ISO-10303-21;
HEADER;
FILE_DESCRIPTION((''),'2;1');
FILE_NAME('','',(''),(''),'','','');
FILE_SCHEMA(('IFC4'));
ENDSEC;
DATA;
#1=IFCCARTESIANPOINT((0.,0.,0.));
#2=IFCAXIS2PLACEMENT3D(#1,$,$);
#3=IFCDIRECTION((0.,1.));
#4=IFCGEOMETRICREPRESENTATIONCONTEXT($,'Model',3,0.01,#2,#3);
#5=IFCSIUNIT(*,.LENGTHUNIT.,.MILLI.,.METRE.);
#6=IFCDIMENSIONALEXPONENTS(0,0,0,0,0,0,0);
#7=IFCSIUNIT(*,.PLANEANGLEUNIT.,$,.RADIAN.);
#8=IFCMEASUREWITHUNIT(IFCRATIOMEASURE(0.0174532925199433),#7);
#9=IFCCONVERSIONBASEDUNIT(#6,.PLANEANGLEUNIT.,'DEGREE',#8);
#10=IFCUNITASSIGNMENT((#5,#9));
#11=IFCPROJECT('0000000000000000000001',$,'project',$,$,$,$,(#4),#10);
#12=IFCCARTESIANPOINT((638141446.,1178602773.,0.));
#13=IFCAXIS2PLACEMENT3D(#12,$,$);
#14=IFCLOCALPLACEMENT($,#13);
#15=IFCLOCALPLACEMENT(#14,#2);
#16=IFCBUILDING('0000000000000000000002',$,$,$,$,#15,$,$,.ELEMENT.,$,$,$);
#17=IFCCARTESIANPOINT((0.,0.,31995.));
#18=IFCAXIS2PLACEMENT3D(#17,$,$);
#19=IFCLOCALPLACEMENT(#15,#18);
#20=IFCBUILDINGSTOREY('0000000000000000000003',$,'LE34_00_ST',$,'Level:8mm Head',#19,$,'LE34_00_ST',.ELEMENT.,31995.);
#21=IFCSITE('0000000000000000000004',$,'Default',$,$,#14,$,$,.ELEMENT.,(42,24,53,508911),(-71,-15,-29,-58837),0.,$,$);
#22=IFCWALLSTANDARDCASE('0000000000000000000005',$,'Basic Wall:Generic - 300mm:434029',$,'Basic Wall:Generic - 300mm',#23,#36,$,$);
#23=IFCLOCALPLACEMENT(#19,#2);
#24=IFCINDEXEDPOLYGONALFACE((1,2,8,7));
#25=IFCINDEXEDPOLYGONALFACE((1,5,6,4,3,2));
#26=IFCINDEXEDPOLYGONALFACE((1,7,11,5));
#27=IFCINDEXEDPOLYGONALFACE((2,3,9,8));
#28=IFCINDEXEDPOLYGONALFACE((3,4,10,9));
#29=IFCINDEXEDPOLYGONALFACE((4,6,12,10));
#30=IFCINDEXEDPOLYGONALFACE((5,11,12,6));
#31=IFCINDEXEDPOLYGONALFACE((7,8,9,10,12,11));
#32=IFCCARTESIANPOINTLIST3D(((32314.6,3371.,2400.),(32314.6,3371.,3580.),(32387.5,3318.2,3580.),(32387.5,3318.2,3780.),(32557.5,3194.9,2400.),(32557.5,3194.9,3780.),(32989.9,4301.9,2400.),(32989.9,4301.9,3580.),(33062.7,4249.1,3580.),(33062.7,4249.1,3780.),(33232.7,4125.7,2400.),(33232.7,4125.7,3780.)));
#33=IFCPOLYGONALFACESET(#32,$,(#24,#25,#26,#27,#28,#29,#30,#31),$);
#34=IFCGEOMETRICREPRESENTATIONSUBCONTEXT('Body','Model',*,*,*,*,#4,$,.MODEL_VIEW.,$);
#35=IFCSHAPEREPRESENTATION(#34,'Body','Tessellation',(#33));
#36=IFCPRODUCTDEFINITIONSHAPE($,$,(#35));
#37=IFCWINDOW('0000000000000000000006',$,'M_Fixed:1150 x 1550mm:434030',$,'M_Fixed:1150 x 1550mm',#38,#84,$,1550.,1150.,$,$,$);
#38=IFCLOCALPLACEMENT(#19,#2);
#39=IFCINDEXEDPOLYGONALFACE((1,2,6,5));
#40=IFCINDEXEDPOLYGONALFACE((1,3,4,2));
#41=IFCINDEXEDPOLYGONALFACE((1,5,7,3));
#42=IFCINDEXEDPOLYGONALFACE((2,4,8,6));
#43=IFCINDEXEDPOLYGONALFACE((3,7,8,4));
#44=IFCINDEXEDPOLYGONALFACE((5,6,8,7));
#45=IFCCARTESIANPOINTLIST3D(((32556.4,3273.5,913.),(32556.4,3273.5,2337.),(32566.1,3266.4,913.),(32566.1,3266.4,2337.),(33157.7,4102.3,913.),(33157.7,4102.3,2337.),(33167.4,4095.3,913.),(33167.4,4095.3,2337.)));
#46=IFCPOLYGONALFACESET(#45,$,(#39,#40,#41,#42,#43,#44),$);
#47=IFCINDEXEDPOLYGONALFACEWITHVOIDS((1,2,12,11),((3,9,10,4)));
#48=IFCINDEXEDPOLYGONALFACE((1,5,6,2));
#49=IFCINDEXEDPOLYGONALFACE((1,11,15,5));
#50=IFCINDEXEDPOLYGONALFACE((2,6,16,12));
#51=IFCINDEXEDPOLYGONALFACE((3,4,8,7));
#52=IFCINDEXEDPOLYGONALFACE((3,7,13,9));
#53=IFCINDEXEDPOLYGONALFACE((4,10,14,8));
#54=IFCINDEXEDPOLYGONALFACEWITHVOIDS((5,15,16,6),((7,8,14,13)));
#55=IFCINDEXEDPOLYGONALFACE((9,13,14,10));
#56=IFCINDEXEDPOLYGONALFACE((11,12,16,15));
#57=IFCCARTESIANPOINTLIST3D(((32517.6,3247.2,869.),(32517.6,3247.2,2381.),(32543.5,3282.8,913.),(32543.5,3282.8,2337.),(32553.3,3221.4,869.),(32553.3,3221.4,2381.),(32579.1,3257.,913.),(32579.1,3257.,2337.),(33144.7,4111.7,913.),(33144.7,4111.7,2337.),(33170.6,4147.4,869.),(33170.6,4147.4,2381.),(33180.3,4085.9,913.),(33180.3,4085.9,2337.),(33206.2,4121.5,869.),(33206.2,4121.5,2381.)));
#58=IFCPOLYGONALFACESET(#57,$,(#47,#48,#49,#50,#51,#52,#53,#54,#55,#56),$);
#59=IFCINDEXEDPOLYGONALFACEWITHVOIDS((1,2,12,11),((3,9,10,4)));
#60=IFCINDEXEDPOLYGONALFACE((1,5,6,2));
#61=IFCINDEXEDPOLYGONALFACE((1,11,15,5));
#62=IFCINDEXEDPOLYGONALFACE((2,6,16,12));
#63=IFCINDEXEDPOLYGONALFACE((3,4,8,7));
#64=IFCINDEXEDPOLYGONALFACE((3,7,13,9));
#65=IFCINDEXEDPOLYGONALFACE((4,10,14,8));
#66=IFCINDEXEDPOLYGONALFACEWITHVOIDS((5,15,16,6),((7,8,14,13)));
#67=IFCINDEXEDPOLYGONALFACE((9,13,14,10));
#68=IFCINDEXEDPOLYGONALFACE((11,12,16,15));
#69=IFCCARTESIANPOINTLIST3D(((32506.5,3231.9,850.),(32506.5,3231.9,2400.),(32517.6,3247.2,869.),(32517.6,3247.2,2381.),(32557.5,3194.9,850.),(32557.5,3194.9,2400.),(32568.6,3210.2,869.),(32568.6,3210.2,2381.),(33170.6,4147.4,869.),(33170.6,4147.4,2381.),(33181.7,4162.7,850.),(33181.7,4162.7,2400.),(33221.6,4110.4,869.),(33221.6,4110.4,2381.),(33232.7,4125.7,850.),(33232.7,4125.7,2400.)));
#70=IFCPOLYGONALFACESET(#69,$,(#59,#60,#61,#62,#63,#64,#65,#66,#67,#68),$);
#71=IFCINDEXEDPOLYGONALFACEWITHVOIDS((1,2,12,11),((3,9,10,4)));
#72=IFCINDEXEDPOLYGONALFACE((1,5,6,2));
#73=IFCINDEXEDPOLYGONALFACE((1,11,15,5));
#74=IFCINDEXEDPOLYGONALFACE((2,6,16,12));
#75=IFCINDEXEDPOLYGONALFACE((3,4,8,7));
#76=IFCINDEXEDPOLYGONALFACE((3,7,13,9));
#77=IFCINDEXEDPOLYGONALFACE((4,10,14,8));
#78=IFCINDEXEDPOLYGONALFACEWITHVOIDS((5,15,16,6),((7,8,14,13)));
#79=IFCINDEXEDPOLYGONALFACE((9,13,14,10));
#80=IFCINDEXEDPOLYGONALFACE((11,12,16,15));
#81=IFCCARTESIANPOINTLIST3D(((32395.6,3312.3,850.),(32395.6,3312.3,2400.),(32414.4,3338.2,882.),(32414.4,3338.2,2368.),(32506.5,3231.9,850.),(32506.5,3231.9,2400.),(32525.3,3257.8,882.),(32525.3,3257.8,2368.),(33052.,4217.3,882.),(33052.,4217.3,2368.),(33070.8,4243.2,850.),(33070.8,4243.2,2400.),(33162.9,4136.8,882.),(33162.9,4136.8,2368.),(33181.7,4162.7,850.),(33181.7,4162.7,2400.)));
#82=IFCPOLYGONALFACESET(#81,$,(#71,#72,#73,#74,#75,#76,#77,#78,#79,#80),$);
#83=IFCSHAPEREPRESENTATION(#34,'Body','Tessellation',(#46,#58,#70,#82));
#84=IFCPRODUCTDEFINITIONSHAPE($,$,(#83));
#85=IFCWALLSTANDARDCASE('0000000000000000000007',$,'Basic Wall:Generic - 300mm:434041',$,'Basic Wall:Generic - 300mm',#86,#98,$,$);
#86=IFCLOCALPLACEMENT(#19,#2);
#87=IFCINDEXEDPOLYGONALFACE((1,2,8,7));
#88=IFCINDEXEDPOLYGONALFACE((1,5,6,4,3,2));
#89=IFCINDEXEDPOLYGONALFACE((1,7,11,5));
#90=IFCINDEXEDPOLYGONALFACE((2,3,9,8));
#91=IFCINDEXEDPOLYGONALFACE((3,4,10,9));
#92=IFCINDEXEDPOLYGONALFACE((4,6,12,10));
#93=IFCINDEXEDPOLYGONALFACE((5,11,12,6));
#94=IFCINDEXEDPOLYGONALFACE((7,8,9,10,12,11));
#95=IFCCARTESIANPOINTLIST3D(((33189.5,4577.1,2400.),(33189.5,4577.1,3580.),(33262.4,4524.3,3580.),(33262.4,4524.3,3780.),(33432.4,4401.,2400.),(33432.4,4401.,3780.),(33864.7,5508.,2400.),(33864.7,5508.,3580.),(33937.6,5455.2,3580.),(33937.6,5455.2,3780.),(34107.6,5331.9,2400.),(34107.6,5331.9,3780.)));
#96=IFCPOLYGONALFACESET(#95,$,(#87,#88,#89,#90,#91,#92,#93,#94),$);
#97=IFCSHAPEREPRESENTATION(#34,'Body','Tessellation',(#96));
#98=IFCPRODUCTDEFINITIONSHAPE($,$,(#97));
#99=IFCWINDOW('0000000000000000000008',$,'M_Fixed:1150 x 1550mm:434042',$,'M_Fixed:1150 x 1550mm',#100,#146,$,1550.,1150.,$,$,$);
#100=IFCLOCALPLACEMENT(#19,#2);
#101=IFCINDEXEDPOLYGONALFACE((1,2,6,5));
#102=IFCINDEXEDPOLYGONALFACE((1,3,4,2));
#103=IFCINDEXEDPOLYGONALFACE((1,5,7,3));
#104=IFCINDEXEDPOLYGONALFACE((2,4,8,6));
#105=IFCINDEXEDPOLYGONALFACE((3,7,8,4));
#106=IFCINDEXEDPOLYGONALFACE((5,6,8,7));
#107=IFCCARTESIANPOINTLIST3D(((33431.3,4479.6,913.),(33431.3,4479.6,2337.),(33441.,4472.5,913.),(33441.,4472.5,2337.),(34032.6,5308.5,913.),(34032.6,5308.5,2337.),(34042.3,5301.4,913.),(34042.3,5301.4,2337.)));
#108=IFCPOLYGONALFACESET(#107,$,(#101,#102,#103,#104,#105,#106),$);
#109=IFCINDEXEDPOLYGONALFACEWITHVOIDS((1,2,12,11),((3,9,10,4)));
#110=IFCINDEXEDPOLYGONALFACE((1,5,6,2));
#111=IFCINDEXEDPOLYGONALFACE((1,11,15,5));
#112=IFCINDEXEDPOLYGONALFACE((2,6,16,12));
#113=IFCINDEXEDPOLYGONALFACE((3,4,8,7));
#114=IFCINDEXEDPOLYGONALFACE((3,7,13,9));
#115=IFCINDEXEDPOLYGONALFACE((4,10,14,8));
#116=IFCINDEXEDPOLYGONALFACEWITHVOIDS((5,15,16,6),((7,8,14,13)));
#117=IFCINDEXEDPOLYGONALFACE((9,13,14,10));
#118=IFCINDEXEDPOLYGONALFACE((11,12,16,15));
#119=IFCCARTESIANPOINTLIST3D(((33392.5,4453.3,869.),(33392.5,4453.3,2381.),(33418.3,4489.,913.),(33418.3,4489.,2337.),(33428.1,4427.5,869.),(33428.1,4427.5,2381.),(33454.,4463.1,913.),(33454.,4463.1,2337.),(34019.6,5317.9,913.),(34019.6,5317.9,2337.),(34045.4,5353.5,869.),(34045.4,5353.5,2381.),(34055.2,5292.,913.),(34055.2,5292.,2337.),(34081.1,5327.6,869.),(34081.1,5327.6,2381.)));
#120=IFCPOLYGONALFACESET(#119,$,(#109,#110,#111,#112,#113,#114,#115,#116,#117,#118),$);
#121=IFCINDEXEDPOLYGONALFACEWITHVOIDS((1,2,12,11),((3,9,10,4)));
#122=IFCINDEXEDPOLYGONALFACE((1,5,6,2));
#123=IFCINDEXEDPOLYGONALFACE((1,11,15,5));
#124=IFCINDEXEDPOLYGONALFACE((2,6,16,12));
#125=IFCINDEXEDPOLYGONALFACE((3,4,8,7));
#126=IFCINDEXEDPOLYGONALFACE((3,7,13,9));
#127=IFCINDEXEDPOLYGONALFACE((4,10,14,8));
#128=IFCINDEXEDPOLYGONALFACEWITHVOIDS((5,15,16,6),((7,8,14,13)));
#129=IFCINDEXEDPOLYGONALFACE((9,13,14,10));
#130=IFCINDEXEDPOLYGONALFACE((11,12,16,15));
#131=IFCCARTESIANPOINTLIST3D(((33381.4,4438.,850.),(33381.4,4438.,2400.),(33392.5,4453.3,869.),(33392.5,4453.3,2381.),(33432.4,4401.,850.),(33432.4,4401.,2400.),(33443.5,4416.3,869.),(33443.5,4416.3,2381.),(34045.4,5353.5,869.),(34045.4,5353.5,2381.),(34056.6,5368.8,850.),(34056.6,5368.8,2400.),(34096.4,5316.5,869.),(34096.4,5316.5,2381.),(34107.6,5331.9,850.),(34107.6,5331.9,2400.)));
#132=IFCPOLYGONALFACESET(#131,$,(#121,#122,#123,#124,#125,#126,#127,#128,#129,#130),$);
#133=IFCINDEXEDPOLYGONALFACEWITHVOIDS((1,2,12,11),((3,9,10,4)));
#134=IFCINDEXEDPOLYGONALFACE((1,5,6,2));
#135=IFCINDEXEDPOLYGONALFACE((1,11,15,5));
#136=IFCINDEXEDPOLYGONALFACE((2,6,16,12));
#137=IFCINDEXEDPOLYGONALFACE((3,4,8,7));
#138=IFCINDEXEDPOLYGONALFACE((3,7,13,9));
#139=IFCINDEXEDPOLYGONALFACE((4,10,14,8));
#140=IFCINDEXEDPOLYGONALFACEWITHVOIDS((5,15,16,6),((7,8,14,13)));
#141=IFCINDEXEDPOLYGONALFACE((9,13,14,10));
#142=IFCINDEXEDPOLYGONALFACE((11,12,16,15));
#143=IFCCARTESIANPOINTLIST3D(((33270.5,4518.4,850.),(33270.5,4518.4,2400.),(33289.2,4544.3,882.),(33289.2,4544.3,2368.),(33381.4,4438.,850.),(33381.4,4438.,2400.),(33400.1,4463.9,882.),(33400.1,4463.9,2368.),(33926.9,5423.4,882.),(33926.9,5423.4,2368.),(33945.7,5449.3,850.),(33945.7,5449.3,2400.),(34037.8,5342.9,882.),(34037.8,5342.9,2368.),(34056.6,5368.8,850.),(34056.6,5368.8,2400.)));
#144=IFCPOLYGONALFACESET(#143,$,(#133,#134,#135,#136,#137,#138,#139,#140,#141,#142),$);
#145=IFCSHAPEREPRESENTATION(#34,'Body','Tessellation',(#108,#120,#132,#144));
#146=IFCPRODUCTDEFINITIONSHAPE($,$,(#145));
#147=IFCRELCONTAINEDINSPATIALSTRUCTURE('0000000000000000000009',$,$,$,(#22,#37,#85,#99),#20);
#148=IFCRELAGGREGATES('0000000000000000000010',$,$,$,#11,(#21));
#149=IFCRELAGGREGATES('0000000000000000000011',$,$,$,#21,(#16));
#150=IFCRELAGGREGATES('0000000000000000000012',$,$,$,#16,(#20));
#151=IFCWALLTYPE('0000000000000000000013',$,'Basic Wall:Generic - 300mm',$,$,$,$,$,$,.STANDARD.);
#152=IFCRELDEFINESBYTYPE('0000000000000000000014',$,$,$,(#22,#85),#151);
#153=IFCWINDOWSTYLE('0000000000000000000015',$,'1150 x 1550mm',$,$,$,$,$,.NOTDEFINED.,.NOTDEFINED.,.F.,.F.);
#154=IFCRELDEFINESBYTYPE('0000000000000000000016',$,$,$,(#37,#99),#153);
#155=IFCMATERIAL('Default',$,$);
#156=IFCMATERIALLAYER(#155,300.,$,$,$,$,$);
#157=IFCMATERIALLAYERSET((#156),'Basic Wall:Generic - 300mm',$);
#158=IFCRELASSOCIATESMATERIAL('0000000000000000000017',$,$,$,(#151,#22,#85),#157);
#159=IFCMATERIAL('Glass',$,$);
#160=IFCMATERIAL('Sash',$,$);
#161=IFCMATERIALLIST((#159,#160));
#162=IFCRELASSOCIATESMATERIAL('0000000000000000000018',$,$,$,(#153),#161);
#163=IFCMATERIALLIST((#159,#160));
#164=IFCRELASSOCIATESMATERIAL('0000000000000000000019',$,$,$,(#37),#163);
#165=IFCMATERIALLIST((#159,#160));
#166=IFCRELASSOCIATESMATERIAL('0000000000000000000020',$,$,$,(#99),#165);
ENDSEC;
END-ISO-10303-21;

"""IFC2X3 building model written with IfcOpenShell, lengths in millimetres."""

from ifc_helpers import new_model, entity, si_unit, converted_unit, direction, frame, frame_2d, origin, place, context, subcontext, project, spatial, polyline, rectangle, outline, extrude, clip, bounded_halfspace, source, transform, mapped, material, material_list, layer, layer_set, layer_usage, type_object, type_shapes, element, fill, save


model = new_model("IFC2X3")

# Units and contexts
model_context = context("Model", 3, precision=0.01, world=origin(), true_north=direction((0.0, 1.0)))
body_context = subcontext(model_context, "Body", "Model", "MODEL_VIEW")
ifc_project = project(units=[si_unit("LENGTHUNIT", "METRE", prefix="MILLI"), converted_unit("PLANEANGLEUNIT", "DEGREE", entity("IfcRatioMeasure", 0.0174532925199433), si_unit("PLANEANGLEUNIT", "RADIAN"), dimensions=[0, 0, 0, 0, 0, 0, 0])], contexts=[model_context])

# Site, building, storey
site_placement = place(None, frame((638141446.0, 1178602773.0, 0.0)))
site = spatial("IfcSite", under=ifc_project, at=site_placement, Name="Default", CompositionType="ELEMENT", RefLatitude=(42, 24, 53, 508911), RefLongitude=(-71, -15, -29, -58837), RefElevation=0.0)
building_placement = place(site_placement, origin())
building = spatial("IfcBuilding", under=site, at=building_placement, CompositionType="ELEMENT")
storey_placement = place(building_placement, frame((0.0, 0.0, 31995.0)))
storey = spatial("IfcBuildingStorey", under=building, at=storey_placement, Name="LE34_00_ST", ObjectType="Level:8mm Head", LongName="LE34_00_ST", CompositionType="ELEMENT", Elevation=31995.0)

# Walls, openings, windows
ifc_material_1 = material(Name="Default")
ifc_layer_1 = layer(ifc_material_1, 300.0)
ifc_layer_set_1 = layer_set([ifc_layer_1], Name="Basic Wall:Generic - 300mm")
ifc_layer_usage_1 = layer_usage(ifc_layer_set_1, "AXIS2", "POSITIVE", -150.0)
wall_type_1 = type_object("IfcWallType", Name="Basic Wall:Generic - 300mm", PredefinedType="STANDARD", material=ifc_layer_set_1)
wall_1_placement = place(storey_placement, frame((32436.1, 3282.9, 2400.0), z_axis=(0.0, 0.0, 1.0), x_axis=(0.587164, 0.809468, 0.0)))
wall_1 = element("IfcWallStandardCase", 1, at=wall_1_placement, inside=storey, type_object=wall_type_1, material=ifc_layer_usage_1, Name="Basic Wall:Generic - 300mm:434029", ObjectType="Basic Wall:Generic - 300mm", context=body_context, shape_type="Clipping", body=[
    clip(clip(extrude(rectangle(XDim=1150.0, YDim=300.0, at=frame_2d((575.0, 0.0), x_axis=(-1.0, 0.0))), origin(), (0.0, 0.0, 1.0), 1380.0), bounded_halfspace(frame((0.0, 60.0, 1180.0), z_axis=(0.0, 0.0, -1.0), x_axis=(0.0, 1.0, 0.0)), True, frame((0.0, 60.0, 1180.0), z_axis=(0.0, 0.0, -1.0), x_axis=(0.0, 1.0, 0.0)), polyline([(0.0, 0.0), (90.0, 0.0), (90.0, 1150.0), (0.0, 1150.0), (0.0, 0.0)]))), bounded_halfspace(frame((1150.0, 60.0, 1180.0), z_axis=(0.0, -1.0, 0.0), x_axis=(0.0, 0.0, 1.0)), True, frame((1150.0, 60.0, 1180.0), z_axis=(0.0, -1.0, 0.0), x_axis=(0.0, 0.0, 1.0)), polyline([(0.0, 0.0), (200.0, 0.0), (200.0, 1150.0), (0.0, 1150.0), (0.0, 0.0)]))),
])
opening_1_placement = place(wall_1_placement, frame((1150.0, 150.0, -1550.0)))
opening_1 = element("IfcOpeningElement", 2, at=opening_1_placement, cuts=wall_1, ObjectType="Opening", context=body_context, shape_type="SweptSolid", body=[
    extrude(rectangle(XDim=1550.0, YDim=1150.0, at=frame_2d((775.0, 575.0), x_axis=(1.0, 0.0))), frame((0.0, 0.0, 0.0), z_axis=(0.0, -1.0, 0.0), x_axis=(0.0, 0.0, 1.0)), (0.0, 0.0, 1.0), 300.0),
])
ifc_material_2 = material(Name="Glass")
ifc_material_3 = material(Name="Sash")
ifc_material_list_1 = material_list([ifc_material_2, ifc_material_3])
ifc_material_list_2 = material_list([ifc_material_2, ifc_material_3])
window_style_1 = type_object("IfcWindowStyle", Name="1150 x 1550mm", ConstructionType="NOTDEFINED", OperationType="NOTDEFINED", ParameterTakesPrecedence=False, Sizeable=False, material=ifc_material_list_2)
shared_shape_1 = source(origin(), body_context, "Body", "SweptSolid", [
    extrude(rectangle(XDim=1024.0, YDim=12.0, at=frame_2d((0.0, 0.0), x_axis=(1.0, 0.0))), frame((575.0, 285.0, 63.0), z_axis=(0.0, 0.0, 1.0), x_axis=(-1.0, 0.0, 0.0)), (0.0, 0.0, 1.0), 1424.0),
    extrude(outline(polyline([(-556.0, -756.0), (556.0, -756.0), (556.0, 756.0), (-556.0, 756.0), (-556.0, -756.0)]), holes=[polyline([(-512.0, -712.0), (-512.0, 712.0), (512.0, 712.0), (512.0, -712.0), (-512.0, -712.0)])]), frame((575.0, 307.0, 775.0), z_axis=(0.0, -1.0, 0.0), x_axis=(-1.0, 0.0, 0.0)), (0.0, 0.0, 1.0), 44.0),
    extrude(outline(polyline([(-575.0, -775.0), (575.0, -775.0), (575.0, 775.0), (-575.0, 775.0), (-575.0, -775.0)]), holes=[polyline([(-556.0, -756.0), (-556.0, 756.0), (556.0, 756.0), (556.0, -756.0), (-556.0, -756.0)])]), frame((575.0, 326.0, 775.0), z_axis=(0.0, -1.0, 0.0), x_axis=(-1.0, 0.0, 0.0)), (0.0, 0.0, 1.0), 63.0),
    extrude(outline(polyline([(-575.0, -775.0), (575.0, -775.0), (575.0, 775.0), (-575.0, 775.0), (-575.0, -775.0)]), holes=[polyline([(-543.0, -743.0), (-543.0, 743.0), (543.0, 743.0), (543.0, -743.0), (-543.0, -743.0)])]), frame((575.0, 263.0, 775.0), z_axis=(0.0, -1.0, 0.0), x_axis=(-1.0, 0.0, 0.0)), (0.0, 0.0, 1.0), 137.0),
])
type_shapes(window_style_1, [shared_shape_1])
window_1_placement = place(opening_1_placement, frame((0.0, 26.0, 0.0), z_axis=(0.0, 0.0, 1.0), x_axis=(-1.0, 0.0, 0.0)))
window_1 = element("IfcWindow", 3, at=window_1_placement, inside=storey, type_object=window_style_1, material=ifc_material_list_1, Name="M_Fixed:1150 x 1550mm:434030", ObjectType="M_Fixed:1150 x 1550mm", OverallHeight=1550.0, OverallWidth=1150.0, context=body_context, shape_type="MappedRepresentation", body=[
    mapped(shared_shape_1, transform((0.0, 0.0, 0.0), scale=1.0)),
])
fill(opening_1, window_1)
ifc_layer_usage_2 = layer_usage(ifc_layer_set_1, "AXIS2", "POSITIVE", -150.0)
wall_2_placement = place(storey_placement, frame((33310.9, 4489.0, 2400.0), z_axis=(0.0, 0.0, 1.0), x_axis=(0.587164, 0.809468, 0.0)))
wall_2 = element("IfcWallStandardCase", 4, at=wall_2_placement, inside=storey, type_object=wall_type_1, material=ifc_layer_usage_2, Name="Basic Wall:Generic - 300mm:434041", ObjectType="Basic Wall:Generic - 300mm", context=body_context, shape_type="Clipping", body=[
    clip(clip(extrude(rectangle(XDim=1150.0, YDim=300.0, at=frame_2d((575.0, 0.0), x_axis=(-1.0, 0.0))), origin(), (0.0, 0.0, 1.0), 1380.0), bounded_halfspace(frame((0.0, 60.0, 1180.0), z_axis=(0.0, 0.0, -1.0), x_axis=(0.0, 1.0, 0.0)), True, frame((0.0, 60.0, 1180.0), z_axis=(0.0, 0.0, -1.0), x_axis=(0.0, 1.0, 0.0)), polyline([(0.0, 0.0), (90.0, 0.0), (90.0, 1150.0), (0.0, 1150.0), (0.0, 0.0)]))), bounded_halfspace(frame((1150.0, 60.0, 1180.0), z_axis=(0.0, -1.0, 0.0), x_axis=(0.0, 0.0, 1.0)), True, frame((1150.0, 60.0, 1180.0), z_axis=(0.0, -1.0, 0.0), x_axis=(0.0, 0.0, 1.0)), polyline([(0.0, 0.0), (200.0, 0.0), (200.0, 1150.0), (0.0, 1150.0), (0.0, 0.0)]))),
])
opening_2_placement = place(wall_2_placement, frame((1150.0, 150.0, -1550.0)))
opening_2 = element("IfcOpeningElement", 5, at=opening_2_placement, cuts=wall_2, ObjectType="Opening", context=body_context, shape_type="SweptSolid", body=[
    extrude(rectangle(XDim=1550.0, YDim=1150.0, at=frame_2d((775.0, 575.0), x_axis=(1.0, 0.0))), frame((0.0, 0.0, 0.0), z_axis=(0.0, -1.0, 0.0), x_axis=(0.0, 0.0, 1.0)), (0.0, 0.0, 1.0), 300.0),
])
ifc_material_list_3 = material_list([ifc_material_2, ifc_material_3])
window_2_placement = place(opening_2_placement, frame((0.0, 26.0, 0.0), z_axis=(0.0, 0.0, 1.0), x_axis=(-1.0, 0.0, 0.0)))
window_2 = element("IfcWindow", 6, at=window_2_placement, inside=storey, type_object=window_style_1, material=ifc_material_list_3, Name="M_Fixed:1150 x 1550mm:434042", ObjectType="M_Fixed:1150 x 1550mm", OverallHeight=1550.0, OverallWidth=1150.0, context=body_context, shape_type="MappedRepresentation", body=[
    mapped(shared_shape_1, transform((0.0, 0.0, 0.0), scale=1.0)),
])
fill(opening_2, window_2)

save(model, "model.ifc")
